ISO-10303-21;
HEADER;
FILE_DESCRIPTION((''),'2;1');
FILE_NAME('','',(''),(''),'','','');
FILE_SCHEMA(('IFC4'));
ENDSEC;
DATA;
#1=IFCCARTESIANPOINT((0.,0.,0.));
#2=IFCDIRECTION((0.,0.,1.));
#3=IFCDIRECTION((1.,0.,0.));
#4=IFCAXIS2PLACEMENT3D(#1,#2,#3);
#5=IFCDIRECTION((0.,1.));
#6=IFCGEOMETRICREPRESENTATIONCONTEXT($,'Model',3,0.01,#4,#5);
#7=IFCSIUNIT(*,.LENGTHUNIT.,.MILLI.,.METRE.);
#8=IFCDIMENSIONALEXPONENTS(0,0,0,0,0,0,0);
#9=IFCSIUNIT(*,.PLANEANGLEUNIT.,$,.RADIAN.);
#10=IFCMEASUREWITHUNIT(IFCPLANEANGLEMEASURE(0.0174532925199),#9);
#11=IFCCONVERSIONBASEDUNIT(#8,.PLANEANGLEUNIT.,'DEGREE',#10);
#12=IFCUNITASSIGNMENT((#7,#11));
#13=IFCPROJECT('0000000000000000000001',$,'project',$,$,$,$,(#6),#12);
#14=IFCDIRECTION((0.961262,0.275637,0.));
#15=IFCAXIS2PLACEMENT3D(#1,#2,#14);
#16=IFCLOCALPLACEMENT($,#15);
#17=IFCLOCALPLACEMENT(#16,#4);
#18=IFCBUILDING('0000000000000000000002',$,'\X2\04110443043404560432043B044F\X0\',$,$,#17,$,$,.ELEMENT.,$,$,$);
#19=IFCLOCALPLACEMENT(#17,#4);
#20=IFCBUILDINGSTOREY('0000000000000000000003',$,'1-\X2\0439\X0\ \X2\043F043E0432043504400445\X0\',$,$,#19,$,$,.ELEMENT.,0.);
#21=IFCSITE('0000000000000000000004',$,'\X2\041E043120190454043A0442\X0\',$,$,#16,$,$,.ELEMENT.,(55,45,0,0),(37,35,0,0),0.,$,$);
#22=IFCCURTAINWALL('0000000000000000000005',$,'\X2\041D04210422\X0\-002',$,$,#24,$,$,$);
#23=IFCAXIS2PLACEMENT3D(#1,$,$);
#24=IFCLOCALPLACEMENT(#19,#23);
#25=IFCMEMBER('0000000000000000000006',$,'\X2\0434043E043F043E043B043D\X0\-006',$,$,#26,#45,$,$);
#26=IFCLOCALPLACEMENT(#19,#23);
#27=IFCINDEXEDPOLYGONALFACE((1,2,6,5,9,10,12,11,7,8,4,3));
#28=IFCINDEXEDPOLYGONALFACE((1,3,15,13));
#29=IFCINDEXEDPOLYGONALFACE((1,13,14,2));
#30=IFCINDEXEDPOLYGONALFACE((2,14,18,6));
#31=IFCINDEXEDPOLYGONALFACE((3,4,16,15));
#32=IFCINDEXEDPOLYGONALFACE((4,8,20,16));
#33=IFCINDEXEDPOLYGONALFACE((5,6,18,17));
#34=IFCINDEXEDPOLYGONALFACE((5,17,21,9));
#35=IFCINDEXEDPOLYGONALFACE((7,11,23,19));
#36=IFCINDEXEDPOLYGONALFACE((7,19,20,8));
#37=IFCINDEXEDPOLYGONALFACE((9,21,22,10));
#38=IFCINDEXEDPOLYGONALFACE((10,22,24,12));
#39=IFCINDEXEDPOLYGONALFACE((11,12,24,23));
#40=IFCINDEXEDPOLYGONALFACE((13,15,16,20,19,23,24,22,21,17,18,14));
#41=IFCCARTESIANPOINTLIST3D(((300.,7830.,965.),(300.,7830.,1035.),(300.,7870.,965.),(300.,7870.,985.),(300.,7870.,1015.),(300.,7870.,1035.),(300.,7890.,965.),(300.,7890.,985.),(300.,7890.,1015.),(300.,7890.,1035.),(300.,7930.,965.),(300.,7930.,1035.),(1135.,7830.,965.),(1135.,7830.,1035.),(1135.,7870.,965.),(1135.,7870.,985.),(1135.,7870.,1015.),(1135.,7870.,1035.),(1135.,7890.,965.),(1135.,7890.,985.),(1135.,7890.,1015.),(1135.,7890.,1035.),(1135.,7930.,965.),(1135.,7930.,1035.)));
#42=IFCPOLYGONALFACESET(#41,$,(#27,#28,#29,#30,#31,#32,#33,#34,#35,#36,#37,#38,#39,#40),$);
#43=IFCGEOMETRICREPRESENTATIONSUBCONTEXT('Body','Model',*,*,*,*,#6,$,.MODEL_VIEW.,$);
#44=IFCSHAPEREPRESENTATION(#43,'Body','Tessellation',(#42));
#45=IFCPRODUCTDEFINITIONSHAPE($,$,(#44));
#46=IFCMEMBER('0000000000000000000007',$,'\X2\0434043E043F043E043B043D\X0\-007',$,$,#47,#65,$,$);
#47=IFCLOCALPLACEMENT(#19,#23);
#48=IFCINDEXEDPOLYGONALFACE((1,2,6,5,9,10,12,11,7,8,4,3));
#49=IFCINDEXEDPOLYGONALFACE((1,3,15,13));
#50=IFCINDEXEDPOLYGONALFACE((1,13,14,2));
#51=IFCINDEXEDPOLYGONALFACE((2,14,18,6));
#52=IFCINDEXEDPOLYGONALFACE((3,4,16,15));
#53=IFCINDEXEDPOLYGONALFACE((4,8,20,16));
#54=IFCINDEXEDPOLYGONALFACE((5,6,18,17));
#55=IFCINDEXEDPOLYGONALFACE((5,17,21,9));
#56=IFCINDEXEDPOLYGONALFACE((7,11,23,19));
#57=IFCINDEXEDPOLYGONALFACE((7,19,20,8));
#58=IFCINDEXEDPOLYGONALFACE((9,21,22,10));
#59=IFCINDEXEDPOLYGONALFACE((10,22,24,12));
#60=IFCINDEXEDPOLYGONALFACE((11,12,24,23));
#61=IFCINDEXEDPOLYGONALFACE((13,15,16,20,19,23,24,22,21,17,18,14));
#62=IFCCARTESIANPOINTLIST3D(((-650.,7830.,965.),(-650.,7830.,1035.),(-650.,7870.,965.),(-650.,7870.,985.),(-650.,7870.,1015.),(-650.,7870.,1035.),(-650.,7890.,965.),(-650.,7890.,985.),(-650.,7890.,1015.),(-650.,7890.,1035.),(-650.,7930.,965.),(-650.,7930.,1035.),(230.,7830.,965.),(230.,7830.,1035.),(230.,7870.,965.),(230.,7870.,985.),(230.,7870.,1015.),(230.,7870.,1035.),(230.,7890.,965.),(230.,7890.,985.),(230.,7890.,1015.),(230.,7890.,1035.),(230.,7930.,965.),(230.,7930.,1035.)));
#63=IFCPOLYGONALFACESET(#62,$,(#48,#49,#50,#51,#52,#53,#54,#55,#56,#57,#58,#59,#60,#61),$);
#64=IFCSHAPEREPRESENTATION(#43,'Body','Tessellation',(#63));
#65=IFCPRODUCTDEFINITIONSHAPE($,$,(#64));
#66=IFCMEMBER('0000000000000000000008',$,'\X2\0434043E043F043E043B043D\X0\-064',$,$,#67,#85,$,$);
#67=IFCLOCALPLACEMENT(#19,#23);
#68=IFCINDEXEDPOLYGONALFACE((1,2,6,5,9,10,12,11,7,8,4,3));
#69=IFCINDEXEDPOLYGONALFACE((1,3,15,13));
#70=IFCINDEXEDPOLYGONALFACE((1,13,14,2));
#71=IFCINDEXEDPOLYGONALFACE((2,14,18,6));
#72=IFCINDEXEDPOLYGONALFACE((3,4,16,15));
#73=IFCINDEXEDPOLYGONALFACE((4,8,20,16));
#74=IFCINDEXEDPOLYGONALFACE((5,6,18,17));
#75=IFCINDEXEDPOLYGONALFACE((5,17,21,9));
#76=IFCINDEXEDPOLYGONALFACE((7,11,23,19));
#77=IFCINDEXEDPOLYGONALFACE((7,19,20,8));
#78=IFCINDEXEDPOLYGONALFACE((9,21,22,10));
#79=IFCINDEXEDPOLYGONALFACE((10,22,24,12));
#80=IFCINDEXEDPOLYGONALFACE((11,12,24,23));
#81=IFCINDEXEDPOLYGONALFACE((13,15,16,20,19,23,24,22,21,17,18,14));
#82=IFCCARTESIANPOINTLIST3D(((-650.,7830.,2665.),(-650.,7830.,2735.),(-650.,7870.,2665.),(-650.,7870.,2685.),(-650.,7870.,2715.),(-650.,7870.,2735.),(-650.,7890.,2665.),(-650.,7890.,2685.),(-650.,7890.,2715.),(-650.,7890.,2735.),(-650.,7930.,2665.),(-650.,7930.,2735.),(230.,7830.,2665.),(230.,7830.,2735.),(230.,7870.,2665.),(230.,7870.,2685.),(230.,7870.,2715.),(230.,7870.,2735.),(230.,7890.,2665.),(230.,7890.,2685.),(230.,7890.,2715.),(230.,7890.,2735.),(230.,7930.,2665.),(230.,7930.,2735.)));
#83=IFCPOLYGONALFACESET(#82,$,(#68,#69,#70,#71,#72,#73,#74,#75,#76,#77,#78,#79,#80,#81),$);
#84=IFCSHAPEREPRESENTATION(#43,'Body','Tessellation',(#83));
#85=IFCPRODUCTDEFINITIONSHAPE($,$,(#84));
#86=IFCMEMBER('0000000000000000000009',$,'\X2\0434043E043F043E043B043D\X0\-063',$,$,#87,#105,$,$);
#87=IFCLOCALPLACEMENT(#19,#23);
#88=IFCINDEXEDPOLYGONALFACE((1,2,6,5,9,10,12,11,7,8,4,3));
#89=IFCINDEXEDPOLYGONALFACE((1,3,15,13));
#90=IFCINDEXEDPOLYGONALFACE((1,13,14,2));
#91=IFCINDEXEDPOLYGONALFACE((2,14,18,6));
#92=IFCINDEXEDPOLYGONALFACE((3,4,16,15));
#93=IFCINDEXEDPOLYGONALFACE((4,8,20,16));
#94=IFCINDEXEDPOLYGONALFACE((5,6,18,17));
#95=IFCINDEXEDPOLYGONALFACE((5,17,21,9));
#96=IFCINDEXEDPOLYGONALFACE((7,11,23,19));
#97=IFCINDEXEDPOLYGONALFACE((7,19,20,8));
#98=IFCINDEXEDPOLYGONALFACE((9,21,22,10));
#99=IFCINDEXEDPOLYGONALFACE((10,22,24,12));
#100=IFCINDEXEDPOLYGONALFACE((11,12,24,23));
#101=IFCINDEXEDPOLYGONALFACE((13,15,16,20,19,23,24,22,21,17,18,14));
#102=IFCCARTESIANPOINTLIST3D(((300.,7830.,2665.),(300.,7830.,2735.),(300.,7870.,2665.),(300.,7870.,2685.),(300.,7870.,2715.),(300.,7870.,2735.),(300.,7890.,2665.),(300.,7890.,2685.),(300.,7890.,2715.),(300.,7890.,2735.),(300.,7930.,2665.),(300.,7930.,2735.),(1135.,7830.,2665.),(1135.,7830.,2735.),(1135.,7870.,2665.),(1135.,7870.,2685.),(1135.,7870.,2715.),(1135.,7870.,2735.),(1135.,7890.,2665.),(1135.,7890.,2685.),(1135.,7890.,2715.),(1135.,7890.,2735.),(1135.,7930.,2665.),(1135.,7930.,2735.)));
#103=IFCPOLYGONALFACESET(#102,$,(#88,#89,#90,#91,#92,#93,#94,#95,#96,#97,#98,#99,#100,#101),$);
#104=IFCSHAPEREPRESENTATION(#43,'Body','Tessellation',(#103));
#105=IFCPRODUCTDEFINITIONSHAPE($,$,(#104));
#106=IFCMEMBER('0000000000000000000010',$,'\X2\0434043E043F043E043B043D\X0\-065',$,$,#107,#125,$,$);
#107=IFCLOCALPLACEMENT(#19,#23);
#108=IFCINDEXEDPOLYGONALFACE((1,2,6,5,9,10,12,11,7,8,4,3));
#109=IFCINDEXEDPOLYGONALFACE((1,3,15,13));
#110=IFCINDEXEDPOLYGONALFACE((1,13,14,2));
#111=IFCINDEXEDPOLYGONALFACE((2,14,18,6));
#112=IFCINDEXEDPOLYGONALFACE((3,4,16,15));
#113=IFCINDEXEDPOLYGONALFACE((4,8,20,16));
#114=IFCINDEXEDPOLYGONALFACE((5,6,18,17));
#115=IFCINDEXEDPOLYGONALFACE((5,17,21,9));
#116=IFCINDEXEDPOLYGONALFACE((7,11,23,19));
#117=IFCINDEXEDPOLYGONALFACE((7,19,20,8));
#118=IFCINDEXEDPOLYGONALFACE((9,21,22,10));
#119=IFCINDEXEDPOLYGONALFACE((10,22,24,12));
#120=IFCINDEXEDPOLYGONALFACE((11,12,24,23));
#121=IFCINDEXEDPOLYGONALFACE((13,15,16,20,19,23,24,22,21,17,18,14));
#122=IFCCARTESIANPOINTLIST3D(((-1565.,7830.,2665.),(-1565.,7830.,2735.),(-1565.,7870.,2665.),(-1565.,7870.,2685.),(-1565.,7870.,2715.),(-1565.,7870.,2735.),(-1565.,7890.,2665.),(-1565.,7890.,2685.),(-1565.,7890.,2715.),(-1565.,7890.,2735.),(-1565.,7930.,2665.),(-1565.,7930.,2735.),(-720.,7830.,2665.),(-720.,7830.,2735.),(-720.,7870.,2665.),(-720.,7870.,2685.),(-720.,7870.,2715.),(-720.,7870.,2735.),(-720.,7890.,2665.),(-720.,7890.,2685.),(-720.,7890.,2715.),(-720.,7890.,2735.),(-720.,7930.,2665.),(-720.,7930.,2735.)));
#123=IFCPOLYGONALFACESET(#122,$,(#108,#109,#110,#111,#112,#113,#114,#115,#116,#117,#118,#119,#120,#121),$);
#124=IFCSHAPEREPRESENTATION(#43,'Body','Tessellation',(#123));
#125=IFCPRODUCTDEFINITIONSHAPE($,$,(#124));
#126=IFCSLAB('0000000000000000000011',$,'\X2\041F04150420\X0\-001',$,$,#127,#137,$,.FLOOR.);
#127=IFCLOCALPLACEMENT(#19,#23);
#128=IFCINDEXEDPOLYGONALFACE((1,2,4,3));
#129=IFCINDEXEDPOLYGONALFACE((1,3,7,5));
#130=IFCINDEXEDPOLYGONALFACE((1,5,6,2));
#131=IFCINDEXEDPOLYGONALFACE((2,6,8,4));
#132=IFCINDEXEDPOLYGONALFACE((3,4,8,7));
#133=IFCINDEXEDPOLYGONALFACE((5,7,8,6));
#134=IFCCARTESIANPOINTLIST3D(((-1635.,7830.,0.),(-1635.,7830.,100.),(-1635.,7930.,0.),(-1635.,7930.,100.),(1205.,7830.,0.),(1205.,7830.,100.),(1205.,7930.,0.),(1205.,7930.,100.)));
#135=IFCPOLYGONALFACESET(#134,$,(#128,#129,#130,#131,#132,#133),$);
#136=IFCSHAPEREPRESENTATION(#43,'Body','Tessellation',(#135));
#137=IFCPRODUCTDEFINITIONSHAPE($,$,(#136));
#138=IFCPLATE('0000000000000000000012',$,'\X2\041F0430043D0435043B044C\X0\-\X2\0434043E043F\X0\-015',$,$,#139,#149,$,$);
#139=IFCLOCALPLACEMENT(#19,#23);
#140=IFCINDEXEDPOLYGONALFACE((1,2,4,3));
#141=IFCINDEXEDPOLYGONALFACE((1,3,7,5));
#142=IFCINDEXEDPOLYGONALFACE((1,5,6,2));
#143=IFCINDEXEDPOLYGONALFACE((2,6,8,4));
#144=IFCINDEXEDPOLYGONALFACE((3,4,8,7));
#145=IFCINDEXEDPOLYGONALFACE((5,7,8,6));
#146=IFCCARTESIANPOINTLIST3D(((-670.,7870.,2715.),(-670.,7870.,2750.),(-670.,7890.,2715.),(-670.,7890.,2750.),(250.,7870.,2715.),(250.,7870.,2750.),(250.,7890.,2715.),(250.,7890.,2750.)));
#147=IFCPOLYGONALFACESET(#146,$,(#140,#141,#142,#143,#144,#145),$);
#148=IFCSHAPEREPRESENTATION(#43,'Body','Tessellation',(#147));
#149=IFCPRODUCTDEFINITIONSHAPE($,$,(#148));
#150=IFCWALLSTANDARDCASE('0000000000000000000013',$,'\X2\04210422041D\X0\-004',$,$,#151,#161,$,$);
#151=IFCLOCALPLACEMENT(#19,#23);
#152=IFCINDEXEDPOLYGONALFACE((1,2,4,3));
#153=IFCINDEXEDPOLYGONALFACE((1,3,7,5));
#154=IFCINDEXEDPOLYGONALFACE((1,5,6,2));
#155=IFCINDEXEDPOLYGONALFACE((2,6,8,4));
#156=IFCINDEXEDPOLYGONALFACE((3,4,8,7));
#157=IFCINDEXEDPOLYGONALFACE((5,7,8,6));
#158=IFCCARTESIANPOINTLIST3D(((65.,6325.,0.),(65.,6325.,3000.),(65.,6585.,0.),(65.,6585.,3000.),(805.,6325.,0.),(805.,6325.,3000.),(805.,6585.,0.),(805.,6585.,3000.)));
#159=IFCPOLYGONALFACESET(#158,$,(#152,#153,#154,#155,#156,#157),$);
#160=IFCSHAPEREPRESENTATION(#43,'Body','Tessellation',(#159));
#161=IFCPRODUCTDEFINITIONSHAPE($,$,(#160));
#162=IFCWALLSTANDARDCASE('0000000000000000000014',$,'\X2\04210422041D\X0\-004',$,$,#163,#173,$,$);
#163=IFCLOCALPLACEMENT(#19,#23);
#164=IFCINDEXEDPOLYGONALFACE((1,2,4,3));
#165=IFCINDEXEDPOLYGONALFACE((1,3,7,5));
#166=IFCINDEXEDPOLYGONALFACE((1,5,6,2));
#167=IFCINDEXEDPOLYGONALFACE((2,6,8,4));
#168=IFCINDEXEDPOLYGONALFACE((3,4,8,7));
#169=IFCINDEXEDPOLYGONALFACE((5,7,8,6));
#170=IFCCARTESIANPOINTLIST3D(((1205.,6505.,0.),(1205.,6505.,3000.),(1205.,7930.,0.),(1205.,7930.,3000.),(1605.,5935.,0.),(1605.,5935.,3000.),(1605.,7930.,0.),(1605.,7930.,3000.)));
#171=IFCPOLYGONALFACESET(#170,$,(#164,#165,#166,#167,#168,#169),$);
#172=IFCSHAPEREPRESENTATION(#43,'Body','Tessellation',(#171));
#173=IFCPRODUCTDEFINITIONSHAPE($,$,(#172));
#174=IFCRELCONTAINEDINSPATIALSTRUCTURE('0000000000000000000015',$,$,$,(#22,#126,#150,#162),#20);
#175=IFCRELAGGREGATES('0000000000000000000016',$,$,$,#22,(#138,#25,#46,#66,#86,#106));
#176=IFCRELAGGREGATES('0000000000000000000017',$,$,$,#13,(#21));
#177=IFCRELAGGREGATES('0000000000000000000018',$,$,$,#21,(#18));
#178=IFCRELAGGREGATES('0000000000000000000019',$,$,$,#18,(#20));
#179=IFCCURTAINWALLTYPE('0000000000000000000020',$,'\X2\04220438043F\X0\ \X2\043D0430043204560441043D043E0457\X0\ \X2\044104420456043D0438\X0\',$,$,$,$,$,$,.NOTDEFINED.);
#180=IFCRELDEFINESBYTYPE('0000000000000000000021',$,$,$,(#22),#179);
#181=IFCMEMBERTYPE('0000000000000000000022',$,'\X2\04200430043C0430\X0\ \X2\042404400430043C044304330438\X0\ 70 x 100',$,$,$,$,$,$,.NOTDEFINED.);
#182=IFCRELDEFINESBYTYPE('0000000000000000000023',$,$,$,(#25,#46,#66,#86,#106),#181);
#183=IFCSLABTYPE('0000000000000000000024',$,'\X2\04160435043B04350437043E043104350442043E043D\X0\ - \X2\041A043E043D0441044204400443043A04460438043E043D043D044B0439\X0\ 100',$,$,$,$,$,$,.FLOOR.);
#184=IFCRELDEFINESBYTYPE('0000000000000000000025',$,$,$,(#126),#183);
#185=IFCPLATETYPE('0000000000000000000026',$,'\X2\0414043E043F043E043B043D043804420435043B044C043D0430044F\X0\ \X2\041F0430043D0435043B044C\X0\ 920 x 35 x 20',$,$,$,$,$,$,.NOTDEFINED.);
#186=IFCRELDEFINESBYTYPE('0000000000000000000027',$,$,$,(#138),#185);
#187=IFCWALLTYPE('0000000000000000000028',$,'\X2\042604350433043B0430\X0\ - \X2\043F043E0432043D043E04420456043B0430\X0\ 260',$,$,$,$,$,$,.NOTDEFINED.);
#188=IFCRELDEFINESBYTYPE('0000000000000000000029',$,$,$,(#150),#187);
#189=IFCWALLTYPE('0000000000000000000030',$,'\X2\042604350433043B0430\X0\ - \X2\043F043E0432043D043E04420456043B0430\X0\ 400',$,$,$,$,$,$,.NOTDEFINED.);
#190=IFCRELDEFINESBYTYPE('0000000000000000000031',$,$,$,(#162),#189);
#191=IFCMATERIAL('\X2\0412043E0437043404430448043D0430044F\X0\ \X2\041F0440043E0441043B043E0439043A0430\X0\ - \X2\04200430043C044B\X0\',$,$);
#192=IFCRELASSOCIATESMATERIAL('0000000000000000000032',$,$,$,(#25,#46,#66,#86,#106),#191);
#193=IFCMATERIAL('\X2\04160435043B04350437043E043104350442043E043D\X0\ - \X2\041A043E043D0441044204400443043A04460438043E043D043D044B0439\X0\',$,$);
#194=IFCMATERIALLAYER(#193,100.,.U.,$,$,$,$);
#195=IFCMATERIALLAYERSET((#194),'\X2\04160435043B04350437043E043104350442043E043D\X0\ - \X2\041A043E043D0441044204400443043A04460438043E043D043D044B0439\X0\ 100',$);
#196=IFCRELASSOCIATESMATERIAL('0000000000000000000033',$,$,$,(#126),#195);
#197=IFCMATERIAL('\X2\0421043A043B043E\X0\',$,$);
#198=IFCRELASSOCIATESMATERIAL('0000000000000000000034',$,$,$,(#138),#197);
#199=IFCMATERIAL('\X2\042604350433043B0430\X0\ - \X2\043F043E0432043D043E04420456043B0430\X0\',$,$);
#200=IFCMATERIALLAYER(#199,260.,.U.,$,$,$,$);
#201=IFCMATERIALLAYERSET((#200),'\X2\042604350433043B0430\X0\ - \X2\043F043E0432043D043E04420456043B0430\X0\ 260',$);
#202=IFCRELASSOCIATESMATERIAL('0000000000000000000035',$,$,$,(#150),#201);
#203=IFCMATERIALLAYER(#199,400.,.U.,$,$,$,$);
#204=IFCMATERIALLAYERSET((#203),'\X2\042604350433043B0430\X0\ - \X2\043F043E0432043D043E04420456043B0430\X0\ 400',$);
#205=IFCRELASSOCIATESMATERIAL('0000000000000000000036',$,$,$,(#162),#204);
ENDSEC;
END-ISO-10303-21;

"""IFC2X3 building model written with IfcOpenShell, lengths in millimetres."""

from ifc_helpers import new_model, entity, si_unit, converted_unit, direction, frame, origin_with_axes, place, context, subcontext, project, spatial, polyline, outline, extrude, material, layer, layer_set, layer_usage, type_object, element, aggregate, save


model = new_model("IFC2X3")

# Units and contexts
model_context = context("Model", 3, precision=0.01, world=origin_with_axes(), true_north=direction((0.0, 1.0)))
body_context = subcontext(model_context, "Body", "Model", "MODEL_VIEW")
ifc_project = project(units=[si_unit("LENGTHUNIT", "METRE", prefix="MILLI"), converted_unit("PLANEANGLEUNIT", "DEGREE", entity("IfcPlaneAngleMeasure", 0.0174532925199), si_unit("PLANEANGLEUNIT", "RADIAN"), dimensions=[0, 0, 0, 0, 0, 0, 0])], contexts=[model_context])

# Site, building, storey
site_placement = place(None, frame((0.0, 0.0, 0.0), z_axis=(0.0, 0.0, 1.0), x_axis=(0.961262, 0.275637, 0.0)))
site = spatial("IfcSite", under=ifc_project, at=site_placement, Name="Об’єкт", CompositionType="ELEMENT", RefLatitude=(55, 45, 0, 0), RefLongitude=(37, 35, 0, 0), RefElevation=0.0)
building_placement = place(site_placement, origin_with_axes())
building = spatial("IfcBuilding", under=site, at=building_placement, Name="Будівля", CompositionType="ELEMENT")
storey_placement = place(building_placement, origin_with_axes())
storey = spatial("IfcBuildingStorey", under=building, at=storey_placement, Name="1-й поверх", CompositionType="ELEMENT", Elevation=0.0)

# Curtain wall, members
curtain_wall_type = type_object("IfcCurtainWallType", Name="Тип навісної стіни", PredefinedType="NOTDEFINED")
curtain_wall_placement = place(storey_placement, frame((-210.0, 7880.0, 100.0), z_axis=(0.0, 0.0, 1.0), x_axis=(1.0, 0.0, 0.0)))
curtain_wall = element("IfcCurtainWall", 1, at=curtain_wall_placement, inside=storey, type_object=curtain_wall_type, Name="НСТ-002")
ifc_material_1 = material(Name="Воздушная Прослойка - Рамы")
member_type_1 = type_object("IfcMemberType", Name="Рама Фрамуги 70 x 100", PredefinedType="NOTDEFINED")
member_1_placement = place(curtain_wall_placement, frame((1415.0, 0.0, 900.0), z_axis=(-1.0, 0.0, 0.0), x_axis=(0.0, 0.0, 1.0)))
member_1 = element("IfcMember", 2, at=member_1_placement, type_object=member_type_1, material=ifc_material_1, Name="дополн-006", context=body_context, shape_type="SweptSolid", body=[
    extrude(outline(polyline([(-10.0, 15.0), (-10.0, 35.0), (-50.0, 35.0), (-50.0, -35.0), (-10.0, -35.0), (-10.0, -15.0), (10.0, -15.0), (10.0, -35.0), (50.0, -35.0), (50.0, 35.0), (10.0, 35.0), (10.0, 15.0), (-10.0, 15.0)])), frame((0.0, 0.0, 70.0), z_axis=(0.0, 0.0, 1.0), x_axis=(0.0, 1.0, 0.0)), (0.0, 0.0, 1.0), 835.0),
])
member_2_placement = place(curtain_wall_placement, frame((475.0, 0.0, 900.0), z_axis=(-1.0, 0.0, 0.0), x_axis=(0.0, 0.0, 1.0)))
member_2 = element("IfcMember", 3, at=member_2_placement, type_object=member_type_1, material=ifc_material_1, Name="дополн-007", context=body_context, shape_type="SweptSolid", body=[
    extrude(outline(polyline([(-10.0, 15.0), (-10.0, 35.0), (-50.0, 35.0), (-50.0, -35.0), (-10.0, -35.0), (-10.0, -15.0), (10.0, -15.0), (10.0, -35.0), (50.0, -35.0), (50.0, 35.0), (10.0, 35.0), (10.0, 15.0), (-10.0, 15.0)])), frame((0.0, 0.0, 35.0), z_axis=(0.0, 0.0, 1.0), x_axis=(0.0, 1.0, 0.0)), (0.0, 0.0, 1.0), 880.0),
])
member_3_placement = place(curtain_wall_placement, frame((475.0, 0.0, 2600.0), z_axis=(-1.0, 0.0, 0.0), x_axis=(0.0, 0.0, 1.0)))
member_3 = element("IfcMember", 4, at=member_3_placement, type_object=member_type_1, material=ifc_material_1, Name="дополн-064", context=body_context, shape_type="SweptSolid", body=[
    extrude(outline(polyline([(-10.0, 15.0), (-10.0, 35.0), (-50.0, 35.0), (-50.0, -35.0), (-10.0, -35.0), (-10.0, -15.0), (10.0, -15.0), (10.0, -35.0), (50.0, -35.0), (50.0, 35.0), (10.0, 35.0), (10.0, 15.0), (-10.0, 15.0)])), frame((0.0, 0.0, 35.0), z_axis=(0.0, 0.0, 1.0), x_axis=(0.0, 1.0, 0.0)), (0.0, 0.0, 1.0), 880.0),
])
member_4_placement = place(curtain_wall_placement, frame((1415.0, 0.0, 2600.0), z_axis=(-1.0, 0.0, 0.0), x_axis=(0.0, 0.0, 1.0)))
member_4 = element("IfcMember", 5, at=member_4_placement, type_object=member_type_1, material=ifc_material_1, Name="дополн-063", context=body_context, shape_type="SweptSolid", body=[
    extrude(outline(polyline([(-10.0, 15.0), (-10.0, 35.0), (-50.0, 35.0), (-50.0, -35.0), (-10.0, -35.0), (-10.0, -15.0), (10.0, -15.0), (10.0, -35.0), (50.0, -35.0), (50.0, 35.0), (10.0, 35.0), (10.0, 15.0), (-10.0, 15.0)])), frame((0.0, 0.0, 70.0), z_axis=(0.0, 0.0, 1.0), x_axis=(0.0, 1.0, 0.0)), (0.0, 0.0, 1.0), 835.0),
])
member_5_placement = place(curtain_wall_placement, frame((-475.0, 0.0, 2600.0), z_axis=(-1.0, 0.0, 0.0), x_axis=(0.0, 0.0, 1.0)))
member_5 = element("IfcMember", 6, at=member_5_placement, type_object=member_type_1, material=ifc_material_1, Name="дополн-065", context=body_context, shape_type="SweptSolid", body=[
    extrude(outline(polyline([(-10.0, 15.0), (-10.0, 35.0), (-50.0, 35.0), (-50.0, -35.0), (-10.0, -35.0), (-10.0, -15.0), (10.0, -15.0), (10.0, -35.0), (50.0, -35.0), (50.0, 35.0), (10.0, 35.0), (10.0, 15.0), (-10.0, 15.0)])), frame((0.0, 0.0, 35.0), z_axis=(0.0, 0.0, 1.0), x_axis=(0.0, 1.0, 0.0)), (0.0, 0.0, 1.0), 845.0),
])

# Slab
ifc_material_2 = material(Name="Железобетон - Конструкционный")
ifc_layer_1 = layer(ifc_material_2, 100.0, ventilated="UNKNOWN")
ifc_layer_set_1 = layer_set([ifc_layer_1], Name="Железобетон - Конструкционный 100")
ifc_layer_usage_1 = layer_usage(ifc_layer_set_1, "AXIS3", "NEGATIVE", 100.0)
slab_type = type_object("IfcSlabType", Name="Железобетон - Конструкционный 100", PredefinedType="FLOOR")
slab_placement = place(storey_placement, frame((1205.0, 7830.0, 100.0), z_axis=(0.0, 0.0, 1.0), x_axis=(1.0, 0.0, 0.0)))
element("IfcSlab", 7, at=slab_placement, inside=storey, type_object=slab_type, material=ifc_layer_usage_1, Name="ПЕР-001", PredefinedType="FLOOR", context=body_context, shape_type="SweptSolid", body=[
    extrude(outline(polyline([(0.0, 0.0), (0.0, 100.0), (-2840.0, 100.0), (-2840.0, 0.0), (0.0, 0.0)])), frame((0.0, 0.0, -100.0), z_axis=(0.0, 0.0, 1.0), x_axis=(1.0, 0.0, 0.0)), (0.0, 0.0, 1.0), 100.0),
])

# Plate
ifc_material_3 = material(Name="Скло")
plate_type_1 = type_object("IfcPlateType", Name="Дополнительная Панель 920 x 35 x 20", PredefinedType="NOTDEFINED")
plate_1_placement = place(curtain_wall_placement, frame((0.0, 0.0, 2650.0), z_axis=(0.0, 0.0, 1.0), x_axis=(1.0, 0.0, 0.0)))
plate_1 = element("IfcPlate", 8, at=plate_1_placement, type_object=plate_type_1, material=ifc_material_3, Name="Панель-доп-015", context=body_context, shape_type="SweptSolid", body=[
    extrude(outline(polyline([(-460.0, 0.0), (460.0, 0.0), (460.0, 35.0), (-460.0, 35.0), (-460.0, 0.0)])), frame((0.0, -10.0, 0.0), z_axis=(0.0, 1.0, 0.0), x_axis=(1.0, 0.0, 0.0)), (0.0, 0.0, 1.0), 20.0),
])
aggregate(curtain_wall, [plate_1, member_1, member_2, member_3, member_4, member_5])

# Walls
ifc_material_4 = material(Name="Цегла - повнотіла")
ifc_layer_2 = layer(ifc_material_4, 260.0, ventilated="UNKNOWN")
ifc_layer_set_2 = layer_set([ifc_layer_2], Name="Цегла - повнотіла 260")
ifc_layer_usage_2 = layer_usage(ifc_layer_set_2, "AXIS2", "POSITIVE", 0.0)
wall_type_1 = type_object("IfcWallType", Name="Цегла - повнотіла 260", PredefinedType="NOTDEFINED")
wall_1_placement = place(storey_placement, frame((805.0, 6585.0, 0.0), z_axis=(0.0, 0.0, 1.0), x_axis=(-1.0, 0.0, 0.0)))
element("IfcWallStandardCase", 9, at=wall_1_placement, inside=storey, type_object=wall_type_1, material=ifc_layer_usage_2, Name="СТН-004", context=body_context, shape_type="SweptSolid", body=[
    extrude(outline(polyline([(0.0, 0.0), (740.0, 0.0), (740.0, 260.0), (0.0, 260.0), (0.0, 0.0)])), origin_with_axes(), (0.0, 0.0, 1.0), 3000.0),
])
ifc_layer_3 = layer(ifc_material_4, 400.0, ventilated="UNKNOWN")
ifc_layer_set_3 = layer_set([ifc_layer_3], Name="Цегла - повнотіла 400")
ifc_layer_usage_3 = layer_usage(ifc_layer_set_3, "AXIS2", "POSITIVE", -400.0)
wall_type_2 = type_object("IfcWallType", Name="Цегла - повнотіла 400", PredefinedType="NOTDEFINED")
wall_2_placement = place(storey_placement, frame((1605.0, 7930.0, 0.0), z_axis=(0.0, 0.0, 1.0), x_axis=(0.0, -1.0, 0.0)))
element("IfcWallStandardCase", 10, at=wall_2_placement, inside=storey, type_object=wall_type_2, material=ifc_layer_usage_3, Name="СТН-004", context=body_context, shape_type="SweptSolid", body=[
    extrude(outline(polyline([(0.0, -400.0), (1425.0, -400.0), (1995.0, 0.0), (0.0, 0.0), (0.0, -400.0)])), origin_with_axes(), (0.0, 0.0, 1.0), 3000.0),
])

save(model, "model.ifc")
